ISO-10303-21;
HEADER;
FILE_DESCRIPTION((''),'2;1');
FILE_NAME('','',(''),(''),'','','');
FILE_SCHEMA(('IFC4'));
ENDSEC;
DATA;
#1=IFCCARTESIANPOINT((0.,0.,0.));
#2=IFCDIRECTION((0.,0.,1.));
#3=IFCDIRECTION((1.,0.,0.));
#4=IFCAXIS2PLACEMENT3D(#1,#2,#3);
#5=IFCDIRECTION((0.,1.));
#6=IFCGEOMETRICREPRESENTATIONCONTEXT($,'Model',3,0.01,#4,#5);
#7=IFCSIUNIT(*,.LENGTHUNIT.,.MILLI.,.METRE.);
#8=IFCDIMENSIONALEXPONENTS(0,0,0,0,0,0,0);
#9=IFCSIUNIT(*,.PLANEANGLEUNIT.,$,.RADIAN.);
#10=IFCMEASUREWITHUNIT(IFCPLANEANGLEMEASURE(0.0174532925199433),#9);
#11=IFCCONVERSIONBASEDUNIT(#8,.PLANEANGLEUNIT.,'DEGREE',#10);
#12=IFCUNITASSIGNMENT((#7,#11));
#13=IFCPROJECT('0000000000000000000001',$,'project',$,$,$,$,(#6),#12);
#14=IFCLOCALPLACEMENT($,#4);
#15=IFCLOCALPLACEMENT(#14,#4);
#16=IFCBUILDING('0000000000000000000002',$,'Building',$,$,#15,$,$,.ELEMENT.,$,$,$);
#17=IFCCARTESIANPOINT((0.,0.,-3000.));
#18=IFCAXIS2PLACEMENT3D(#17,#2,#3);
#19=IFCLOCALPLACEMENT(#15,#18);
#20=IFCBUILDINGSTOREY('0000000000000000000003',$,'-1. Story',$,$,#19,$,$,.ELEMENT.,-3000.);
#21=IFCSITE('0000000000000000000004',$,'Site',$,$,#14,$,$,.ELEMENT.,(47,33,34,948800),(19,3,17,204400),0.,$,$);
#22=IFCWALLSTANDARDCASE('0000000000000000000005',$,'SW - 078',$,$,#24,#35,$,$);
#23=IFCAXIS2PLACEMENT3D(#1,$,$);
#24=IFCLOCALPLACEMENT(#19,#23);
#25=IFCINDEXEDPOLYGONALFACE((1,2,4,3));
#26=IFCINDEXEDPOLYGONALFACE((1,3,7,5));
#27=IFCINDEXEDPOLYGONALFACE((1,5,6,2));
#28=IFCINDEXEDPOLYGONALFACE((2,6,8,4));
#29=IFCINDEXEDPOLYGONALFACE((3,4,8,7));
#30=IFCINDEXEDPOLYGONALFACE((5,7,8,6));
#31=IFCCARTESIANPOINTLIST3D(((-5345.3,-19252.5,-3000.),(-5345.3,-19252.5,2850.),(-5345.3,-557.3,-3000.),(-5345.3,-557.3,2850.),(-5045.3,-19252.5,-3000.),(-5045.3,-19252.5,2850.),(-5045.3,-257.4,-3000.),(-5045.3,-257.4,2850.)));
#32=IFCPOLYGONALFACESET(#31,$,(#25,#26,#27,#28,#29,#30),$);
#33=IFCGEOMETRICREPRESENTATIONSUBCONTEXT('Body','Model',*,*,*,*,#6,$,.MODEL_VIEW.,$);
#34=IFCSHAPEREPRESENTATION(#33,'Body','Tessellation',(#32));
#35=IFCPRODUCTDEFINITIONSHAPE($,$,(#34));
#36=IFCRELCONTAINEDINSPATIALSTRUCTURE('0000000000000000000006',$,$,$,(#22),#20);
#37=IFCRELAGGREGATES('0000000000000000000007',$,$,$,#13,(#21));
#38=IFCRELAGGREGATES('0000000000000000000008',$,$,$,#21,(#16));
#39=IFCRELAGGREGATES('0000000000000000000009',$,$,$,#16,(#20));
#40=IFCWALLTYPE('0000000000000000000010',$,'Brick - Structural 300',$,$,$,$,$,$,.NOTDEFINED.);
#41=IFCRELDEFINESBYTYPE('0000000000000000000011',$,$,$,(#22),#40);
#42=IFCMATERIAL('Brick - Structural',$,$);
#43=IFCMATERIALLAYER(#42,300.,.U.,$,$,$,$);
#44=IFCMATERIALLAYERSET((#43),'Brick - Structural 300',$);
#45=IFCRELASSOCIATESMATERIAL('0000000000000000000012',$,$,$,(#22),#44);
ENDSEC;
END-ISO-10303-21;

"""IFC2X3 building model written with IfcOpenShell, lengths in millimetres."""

from ifc_helpers import new_model, entity, si_unit, converted_unit, direction, frame, origin_with_axes, place, context, subcontext, project, spatial, polyline, outline, extrude, material, layer, layer_set, layer_usage, type_object, element, save


model = new_model("IFC2X3")

# Units and contexts
model_context = context("Model", 3, precision=0.01, world=origin_with_axes(), true_north=direction((0.0, 1.0)))
body_context = subcontext(model_context, "Body", "Model", "MODEL_VIEW")
ifc_project = project(units=[si_unit("LENGTHUNIT", "METRE", prefix="MILLI"), converted_unit("PLANEANGLEUNIT", "DEGREE", entity("IfcPlaneAngleMeasure", 0.0174532925199433), si_unit("PLANEANGLEUNIT", "RADIAN"), dimensions=[0, 0, 0, 0, 0, 0, 0])], contexts=[model_context])

# Site, building, storey
site_placement = place(None, origin_with_axes())
site = spatial("IfcSite", under=ifc_project, at=site_placement, Name="Site", CompositionType="ELEMENT", RefLatitude=(47, 33, 34, 948800), RefLongitude=(19, 3, 17, 204400), RefElevation=0.0)
building_placement = place(site_placement, origin_with_axes())
building = spatial("IfcBuilding", under=site, at=building_placement, Name="Building", CompositionType="ELEMENT")
storey_placement = place(building_placement, frame((0.0, 0.0, -3000.0), z_axis=(0.0, 0.0, 1.0), x_axis=(1.0, 0.0, 0.0)))
storey = spatial("IfcBuildingStorey", under=building, at=storey_placement, Name="-1. Story", CompositionType="ELEMENT", Elevation=-3000.0)

# Wall
ifc_material = material(Name="Brick - Structural")
ifc_layer = layer(ifc_material, 300.0, ventilated="UNKNOWN")
ifc_layer_set = layer_set([ifc_layer], Name="Brick - Structural 300")
ifc_layer_usage = layer_usage(ifc_layer_set, "AXIS2", "POSITIVE", 0.0)
wall_type = type_object("IfcWallType", Name="Brick - Structural 300", PredefinedType="NOTDEFINED")
wall_placement = place(storey_placement, frame((-5045.3, -19252.5, -3000.0), z_axis=(0.0, 0.0, 1.0), x_axis=(0.0, 1.0, 0.0)))
element("IfcWallStandardCase", 1, at=wall_placement, inside=storey, type_object=wall_type, material=ifc_layer_usage, Name="SW - 078", context=body_context, shape_type="SweptSolid", body=[
    extrude(outline(polyline([(0.0, 0.0), (18995.1, 0.0), (18695.2, 300.0), (0.0, 300.0), (0.0, 0.0)])), origin_with_axes(), (0.0, 0.0, 1.0), 5850.0),
])

save(model, "model.ifc")
